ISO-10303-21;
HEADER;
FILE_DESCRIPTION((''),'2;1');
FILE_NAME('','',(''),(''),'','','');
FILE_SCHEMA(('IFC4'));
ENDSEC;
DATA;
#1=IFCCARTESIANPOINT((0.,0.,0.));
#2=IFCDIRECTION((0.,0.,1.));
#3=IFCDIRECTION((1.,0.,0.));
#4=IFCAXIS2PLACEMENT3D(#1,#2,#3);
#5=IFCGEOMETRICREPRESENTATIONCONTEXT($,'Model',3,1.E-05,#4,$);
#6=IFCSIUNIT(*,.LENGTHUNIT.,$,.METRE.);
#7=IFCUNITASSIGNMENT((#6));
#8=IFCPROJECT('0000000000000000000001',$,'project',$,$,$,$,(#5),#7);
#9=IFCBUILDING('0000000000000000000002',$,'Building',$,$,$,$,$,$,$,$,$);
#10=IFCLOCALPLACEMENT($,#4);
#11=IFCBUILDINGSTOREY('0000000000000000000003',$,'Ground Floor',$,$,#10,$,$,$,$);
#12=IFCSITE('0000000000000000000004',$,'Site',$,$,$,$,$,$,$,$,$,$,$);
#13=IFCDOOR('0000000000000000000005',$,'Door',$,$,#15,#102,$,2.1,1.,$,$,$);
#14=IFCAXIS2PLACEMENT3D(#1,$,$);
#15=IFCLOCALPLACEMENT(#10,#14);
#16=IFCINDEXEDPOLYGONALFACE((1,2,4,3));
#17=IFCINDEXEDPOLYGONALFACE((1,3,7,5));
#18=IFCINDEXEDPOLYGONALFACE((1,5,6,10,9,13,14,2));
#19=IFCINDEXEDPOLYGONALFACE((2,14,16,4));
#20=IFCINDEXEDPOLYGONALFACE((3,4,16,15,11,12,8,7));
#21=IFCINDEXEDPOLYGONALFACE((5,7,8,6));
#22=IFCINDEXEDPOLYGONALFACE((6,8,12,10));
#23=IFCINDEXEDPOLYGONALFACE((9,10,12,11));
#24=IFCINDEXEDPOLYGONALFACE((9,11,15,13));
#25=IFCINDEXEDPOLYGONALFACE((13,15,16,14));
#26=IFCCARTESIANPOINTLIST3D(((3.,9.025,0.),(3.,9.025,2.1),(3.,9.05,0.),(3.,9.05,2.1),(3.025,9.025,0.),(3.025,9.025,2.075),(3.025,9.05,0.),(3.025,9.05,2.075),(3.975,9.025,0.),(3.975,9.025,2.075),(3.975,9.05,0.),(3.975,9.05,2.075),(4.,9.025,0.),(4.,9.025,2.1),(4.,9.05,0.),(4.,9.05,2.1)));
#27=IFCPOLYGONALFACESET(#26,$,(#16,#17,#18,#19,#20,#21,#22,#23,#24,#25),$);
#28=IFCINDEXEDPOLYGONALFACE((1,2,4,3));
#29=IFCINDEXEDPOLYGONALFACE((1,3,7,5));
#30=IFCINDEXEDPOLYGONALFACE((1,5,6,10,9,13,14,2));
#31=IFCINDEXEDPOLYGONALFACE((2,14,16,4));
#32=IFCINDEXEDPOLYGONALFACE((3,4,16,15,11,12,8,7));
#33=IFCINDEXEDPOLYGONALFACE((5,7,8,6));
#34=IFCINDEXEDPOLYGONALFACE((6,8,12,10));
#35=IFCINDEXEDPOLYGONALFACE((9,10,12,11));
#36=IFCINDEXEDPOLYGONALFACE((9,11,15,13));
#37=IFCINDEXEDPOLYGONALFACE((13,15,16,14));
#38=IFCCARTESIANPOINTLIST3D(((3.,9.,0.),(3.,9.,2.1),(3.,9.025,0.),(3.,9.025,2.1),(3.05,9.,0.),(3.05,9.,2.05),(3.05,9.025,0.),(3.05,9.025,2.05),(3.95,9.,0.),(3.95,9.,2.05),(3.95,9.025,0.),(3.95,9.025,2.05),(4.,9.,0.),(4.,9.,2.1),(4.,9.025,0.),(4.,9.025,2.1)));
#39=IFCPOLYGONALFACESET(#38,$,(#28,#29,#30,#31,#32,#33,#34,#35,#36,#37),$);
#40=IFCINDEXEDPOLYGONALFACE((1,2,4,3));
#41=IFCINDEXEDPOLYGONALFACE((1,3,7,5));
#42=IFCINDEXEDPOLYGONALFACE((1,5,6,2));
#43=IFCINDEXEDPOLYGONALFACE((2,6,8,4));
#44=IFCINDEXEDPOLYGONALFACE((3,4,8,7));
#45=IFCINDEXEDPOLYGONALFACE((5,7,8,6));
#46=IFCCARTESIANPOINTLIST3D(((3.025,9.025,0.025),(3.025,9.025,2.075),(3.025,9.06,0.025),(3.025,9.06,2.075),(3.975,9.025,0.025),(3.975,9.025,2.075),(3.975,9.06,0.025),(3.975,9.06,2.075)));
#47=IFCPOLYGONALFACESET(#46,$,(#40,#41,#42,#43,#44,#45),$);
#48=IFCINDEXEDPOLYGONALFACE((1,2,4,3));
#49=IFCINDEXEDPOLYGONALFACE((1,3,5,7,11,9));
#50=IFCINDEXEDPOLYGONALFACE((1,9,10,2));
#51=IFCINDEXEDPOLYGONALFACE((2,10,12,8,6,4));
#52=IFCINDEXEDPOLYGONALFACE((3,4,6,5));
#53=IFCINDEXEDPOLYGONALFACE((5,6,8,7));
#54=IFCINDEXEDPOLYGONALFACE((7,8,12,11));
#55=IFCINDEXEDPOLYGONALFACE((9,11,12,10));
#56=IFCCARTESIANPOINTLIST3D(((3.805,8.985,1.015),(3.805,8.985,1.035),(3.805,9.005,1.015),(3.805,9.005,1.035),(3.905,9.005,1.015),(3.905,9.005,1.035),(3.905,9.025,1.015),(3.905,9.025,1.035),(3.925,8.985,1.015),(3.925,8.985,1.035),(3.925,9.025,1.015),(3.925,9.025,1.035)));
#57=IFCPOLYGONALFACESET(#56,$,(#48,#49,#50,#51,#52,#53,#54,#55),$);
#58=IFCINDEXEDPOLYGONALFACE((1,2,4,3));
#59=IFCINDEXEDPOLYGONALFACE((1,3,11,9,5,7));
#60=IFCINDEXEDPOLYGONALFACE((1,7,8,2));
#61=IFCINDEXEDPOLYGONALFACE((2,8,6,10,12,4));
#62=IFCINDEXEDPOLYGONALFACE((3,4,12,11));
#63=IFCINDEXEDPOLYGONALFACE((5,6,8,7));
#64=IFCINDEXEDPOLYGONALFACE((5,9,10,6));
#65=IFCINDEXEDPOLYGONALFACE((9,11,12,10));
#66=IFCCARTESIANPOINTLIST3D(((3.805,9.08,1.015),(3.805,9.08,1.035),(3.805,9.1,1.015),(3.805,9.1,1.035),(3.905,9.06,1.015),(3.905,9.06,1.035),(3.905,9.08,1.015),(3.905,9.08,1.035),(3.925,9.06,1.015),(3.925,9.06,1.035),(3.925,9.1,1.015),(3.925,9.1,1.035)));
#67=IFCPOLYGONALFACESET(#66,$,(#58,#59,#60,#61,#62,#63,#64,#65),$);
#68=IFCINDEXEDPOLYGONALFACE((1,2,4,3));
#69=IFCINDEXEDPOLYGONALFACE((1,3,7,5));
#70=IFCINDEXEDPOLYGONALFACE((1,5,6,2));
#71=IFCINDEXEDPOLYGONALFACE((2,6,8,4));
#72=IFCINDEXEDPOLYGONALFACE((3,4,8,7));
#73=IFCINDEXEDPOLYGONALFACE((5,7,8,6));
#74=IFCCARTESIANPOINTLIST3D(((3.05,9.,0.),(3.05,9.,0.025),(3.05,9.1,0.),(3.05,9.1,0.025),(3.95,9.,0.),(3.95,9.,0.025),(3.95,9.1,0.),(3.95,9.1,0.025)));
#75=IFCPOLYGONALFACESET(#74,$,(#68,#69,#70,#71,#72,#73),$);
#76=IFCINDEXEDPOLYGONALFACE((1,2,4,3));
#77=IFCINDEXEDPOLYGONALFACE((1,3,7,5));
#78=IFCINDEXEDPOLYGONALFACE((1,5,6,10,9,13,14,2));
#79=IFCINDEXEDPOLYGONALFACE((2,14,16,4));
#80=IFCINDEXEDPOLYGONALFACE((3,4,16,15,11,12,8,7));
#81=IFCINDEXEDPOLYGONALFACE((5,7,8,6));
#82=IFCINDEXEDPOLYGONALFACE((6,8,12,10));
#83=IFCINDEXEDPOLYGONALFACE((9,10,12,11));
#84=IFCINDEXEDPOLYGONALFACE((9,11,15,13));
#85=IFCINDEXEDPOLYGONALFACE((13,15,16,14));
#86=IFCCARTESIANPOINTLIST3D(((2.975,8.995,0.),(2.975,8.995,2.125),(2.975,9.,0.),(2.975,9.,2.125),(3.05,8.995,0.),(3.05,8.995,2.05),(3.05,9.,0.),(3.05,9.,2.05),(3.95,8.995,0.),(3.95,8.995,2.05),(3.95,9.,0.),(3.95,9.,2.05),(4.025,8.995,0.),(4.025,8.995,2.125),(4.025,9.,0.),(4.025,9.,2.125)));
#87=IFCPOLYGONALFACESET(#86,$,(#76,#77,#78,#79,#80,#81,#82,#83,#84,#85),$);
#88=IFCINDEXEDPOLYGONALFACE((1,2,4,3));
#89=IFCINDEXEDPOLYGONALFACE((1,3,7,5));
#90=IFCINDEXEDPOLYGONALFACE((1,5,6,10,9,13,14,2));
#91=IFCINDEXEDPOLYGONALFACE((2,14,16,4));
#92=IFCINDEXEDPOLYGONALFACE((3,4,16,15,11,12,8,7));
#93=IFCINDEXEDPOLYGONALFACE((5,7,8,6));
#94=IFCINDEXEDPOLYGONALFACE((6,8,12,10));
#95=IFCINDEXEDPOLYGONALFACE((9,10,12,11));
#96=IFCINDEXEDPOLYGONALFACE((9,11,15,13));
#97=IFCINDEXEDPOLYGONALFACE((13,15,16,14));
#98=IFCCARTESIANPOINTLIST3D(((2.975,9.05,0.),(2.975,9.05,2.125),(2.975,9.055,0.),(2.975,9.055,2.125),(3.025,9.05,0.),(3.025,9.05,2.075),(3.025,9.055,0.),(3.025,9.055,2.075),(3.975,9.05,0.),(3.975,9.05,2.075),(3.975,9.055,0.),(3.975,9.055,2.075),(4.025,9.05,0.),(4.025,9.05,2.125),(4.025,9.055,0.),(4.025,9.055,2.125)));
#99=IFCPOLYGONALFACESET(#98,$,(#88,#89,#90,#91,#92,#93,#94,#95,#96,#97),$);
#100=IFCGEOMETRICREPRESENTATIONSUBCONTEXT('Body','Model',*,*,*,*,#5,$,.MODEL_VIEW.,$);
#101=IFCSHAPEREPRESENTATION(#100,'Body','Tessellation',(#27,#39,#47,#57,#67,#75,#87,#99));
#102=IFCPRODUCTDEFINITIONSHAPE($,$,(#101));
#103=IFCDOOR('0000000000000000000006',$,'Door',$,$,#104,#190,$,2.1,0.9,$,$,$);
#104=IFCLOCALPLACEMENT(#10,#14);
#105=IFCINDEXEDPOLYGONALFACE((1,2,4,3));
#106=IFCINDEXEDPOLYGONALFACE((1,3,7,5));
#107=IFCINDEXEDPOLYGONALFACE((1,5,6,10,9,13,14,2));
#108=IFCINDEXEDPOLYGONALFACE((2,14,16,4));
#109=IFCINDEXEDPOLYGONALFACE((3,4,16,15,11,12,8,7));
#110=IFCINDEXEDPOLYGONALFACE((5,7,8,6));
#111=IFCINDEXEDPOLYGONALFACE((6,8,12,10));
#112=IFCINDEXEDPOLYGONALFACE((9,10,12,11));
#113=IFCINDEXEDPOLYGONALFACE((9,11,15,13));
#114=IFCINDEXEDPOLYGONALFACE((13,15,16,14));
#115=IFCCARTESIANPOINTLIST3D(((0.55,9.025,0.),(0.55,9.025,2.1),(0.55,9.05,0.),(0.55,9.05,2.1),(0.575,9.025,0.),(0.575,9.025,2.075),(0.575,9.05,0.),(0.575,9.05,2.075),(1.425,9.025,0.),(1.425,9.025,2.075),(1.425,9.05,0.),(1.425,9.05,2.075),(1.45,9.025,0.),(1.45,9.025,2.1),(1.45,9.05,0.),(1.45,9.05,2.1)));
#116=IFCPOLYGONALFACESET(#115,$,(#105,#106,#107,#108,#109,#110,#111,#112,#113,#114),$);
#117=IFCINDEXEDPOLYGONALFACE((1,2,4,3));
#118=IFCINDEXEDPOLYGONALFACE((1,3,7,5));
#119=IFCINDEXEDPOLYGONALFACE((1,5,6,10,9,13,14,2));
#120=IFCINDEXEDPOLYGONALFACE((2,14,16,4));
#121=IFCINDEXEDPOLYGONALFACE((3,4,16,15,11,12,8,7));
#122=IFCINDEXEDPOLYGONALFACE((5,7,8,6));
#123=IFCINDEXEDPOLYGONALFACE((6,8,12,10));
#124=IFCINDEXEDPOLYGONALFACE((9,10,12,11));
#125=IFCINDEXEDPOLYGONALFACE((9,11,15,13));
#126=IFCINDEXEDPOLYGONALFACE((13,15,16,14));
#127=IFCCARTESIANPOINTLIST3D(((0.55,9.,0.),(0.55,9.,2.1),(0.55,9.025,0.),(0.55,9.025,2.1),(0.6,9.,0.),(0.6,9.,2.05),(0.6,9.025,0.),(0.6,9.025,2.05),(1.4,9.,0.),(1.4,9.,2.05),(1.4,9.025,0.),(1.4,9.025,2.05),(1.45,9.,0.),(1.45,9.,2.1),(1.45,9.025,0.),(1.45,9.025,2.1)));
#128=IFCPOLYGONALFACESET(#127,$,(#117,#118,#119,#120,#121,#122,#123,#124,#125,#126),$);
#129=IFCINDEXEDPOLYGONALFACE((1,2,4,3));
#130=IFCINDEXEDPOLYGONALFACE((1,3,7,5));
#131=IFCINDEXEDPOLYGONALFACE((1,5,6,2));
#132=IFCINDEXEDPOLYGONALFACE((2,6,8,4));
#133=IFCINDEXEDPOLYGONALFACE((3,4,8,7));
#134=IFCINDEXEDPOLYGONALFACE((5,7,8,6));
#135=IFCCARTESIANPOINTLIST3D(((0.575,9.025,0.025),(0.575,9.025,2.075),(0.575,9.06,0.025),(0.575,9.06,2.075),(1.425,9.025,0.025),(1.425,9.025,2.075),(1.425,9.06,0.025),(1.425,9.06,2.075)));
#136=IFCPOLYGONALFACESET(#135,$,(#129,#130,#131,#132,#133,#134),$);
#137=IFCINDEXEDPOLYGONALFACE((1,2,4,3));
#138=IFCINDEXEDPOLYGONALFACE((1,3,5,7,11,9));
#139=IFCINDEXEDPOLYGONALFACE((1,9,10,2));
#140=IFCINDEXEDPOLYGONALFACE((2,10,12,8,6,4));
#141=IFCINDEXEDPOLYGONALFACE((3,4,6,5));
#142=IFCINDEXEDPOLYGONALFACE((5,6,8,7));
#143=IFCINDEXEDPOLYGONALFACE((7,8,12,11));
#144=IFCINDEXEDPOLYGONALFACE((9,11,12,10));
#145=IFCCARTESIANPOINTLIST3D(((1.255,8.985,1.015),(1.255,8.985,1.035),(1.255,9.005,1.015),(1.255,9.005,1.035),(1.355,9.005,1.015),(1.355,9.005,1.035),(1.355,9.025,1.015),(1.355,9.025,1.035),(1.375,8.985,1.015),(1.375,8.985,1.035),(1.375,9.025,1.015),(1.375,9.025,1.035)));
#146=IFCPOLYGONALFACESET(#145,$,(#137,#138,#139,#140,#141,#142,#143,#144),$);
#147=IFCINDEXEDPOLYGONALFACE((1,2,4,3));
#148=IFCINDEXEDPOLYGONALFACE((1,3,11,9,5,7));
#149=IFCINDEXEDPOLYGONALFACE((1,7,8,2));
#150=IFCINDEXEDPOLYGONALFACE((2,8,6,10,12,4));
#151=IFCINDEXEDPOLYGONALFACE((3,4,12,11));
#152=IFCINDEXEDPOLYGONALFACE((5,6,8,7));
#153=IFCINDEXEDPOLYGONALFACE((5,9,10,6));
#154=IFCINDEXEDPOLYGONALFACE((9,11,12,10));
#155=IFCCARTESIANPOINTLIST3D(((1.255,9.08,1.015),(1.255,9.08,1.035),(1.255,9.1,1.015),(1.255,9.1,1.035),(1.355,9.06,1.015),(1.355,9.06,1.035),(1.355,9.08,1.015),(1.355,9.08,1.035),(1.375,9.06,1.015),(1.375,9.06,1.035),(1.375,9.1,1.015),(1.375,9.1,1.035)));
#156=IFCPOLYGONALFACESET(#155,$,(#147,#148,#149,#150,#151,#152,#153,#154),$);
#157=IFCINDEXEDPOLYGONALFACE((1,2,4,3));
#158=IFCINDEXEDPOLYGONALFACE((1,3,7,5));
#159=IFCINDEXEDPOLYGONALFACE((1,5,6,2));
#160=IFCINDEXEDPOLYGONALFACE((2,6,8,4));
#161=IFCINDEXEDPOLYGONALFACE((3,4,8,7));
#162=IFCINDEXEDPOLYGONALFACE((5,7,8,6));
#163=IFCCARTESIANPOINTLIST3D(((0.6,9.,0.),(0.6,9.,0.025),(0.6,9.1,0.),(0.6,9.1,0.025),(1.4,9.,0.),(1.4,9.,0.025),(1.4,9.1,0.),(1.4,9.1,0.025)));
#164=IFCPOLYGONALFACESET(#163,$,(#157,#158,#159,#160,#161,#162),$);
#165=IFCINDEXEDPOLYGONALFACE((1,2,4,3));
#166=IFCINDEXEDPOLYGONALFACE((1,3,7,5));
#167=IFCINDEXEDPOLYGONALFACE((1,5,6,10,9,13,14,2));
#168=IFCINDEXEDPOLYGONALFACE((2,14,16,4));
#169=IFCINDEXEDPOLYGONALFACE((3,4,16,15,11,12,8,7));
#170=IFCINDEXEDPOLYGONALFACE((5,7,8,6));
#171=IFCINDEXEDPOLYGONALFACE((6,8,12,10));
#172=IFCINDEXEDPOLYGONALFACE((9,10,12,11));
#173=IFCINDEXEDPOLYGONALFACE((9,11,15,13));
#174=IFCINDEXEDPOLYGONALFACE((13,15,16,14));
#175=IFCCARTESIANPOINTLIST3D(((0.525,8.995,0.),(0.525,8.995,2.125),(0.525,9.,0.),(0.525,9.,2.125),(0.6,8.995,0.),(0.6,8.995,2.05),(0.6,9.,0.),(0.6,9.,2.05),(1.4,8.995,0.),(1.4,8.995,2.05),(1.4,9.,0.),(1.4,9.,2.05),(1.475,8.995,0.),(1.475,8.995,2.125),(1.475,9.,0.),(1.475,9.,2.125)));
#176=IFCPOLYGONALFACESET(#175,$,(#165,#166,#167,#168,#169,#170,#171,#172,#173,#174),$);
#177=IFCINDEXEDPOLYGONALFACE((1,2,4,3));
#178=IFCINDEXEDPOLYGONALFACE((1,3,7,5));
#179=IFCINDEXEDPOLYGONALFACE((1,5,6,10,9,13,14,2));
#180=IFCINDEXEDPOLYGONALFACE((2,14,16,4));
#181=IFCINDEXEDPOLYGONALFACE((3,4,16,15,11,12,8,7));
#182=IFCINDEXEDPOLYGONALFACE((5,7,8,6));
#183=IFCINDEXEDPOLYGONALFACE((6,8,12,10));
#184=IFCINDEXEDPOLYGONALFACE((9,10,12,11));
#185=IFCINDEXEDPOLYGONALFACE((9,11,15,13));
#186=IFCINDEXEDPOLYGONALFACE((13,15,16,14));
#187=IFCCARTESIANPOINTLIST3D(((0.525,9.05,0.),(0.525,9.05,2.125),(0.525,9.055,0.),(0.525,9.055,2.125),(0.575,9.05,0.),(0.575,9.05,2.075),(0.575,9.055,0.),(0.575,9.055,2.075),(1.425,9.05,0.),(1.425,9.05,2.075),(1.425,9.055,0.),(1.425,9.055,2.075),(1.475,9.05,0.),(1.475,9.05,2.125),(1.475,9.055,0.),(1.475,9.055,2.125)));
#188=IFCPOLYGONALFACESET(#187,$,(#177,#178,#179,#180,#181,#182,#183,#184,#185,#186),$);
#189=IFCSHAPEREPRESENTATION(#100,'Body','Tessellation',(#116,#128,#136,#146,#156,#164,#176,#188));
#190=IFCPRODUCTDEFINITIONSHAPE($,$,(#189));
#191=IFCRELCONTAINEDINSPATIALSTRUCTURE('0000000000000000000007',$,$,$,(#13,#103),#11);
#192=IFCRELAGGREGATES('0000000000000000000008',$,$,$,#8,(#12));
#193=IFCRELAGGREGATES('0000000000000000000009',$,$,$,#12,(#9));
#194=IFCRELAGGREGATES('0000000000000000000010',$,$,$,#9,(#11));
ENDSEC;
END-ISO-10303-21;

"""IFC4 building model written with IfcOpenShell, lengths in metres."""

from ifc_helpers import new_model, si_unit, frame, origin_with_axes, place, context, subcontext, project, spatial, line, indexed_curve, outline, extrude, element, save


model = new_model("IFC4")

# Units and contexts
model_context = context("Model", 3, precision=1e-05, world=origin_with_axes())
body_context = subcontext(model_context, "Body", "Model", "MODEL_VIEW")
ifc_project = project(units=[si_unit("LENGTHUNIT", "METRE")], contexts=[model_context])

# Site, building, storey
site = spatial("IfcSite", under=ifc_project, Name="Site")
building = spatial("IfcBuilding", under=site, Name="Building")
storey_placement = place(None, origin_with_axes())
storey = spatial("IfcBuildingStorey", under=building, at=storey_placement, Name="Ground Floor")

# Doors
door_1_placement = place(storey_placement, frame((3.0, 9.0, 0.0), z_axis=(0.0, 0.0, 1.0), x_axis=(1.0, 0.0, 0.0)))
element("IfcDoor", 1, at=door_1_placement, inside=storey, Name="Door", OverallHeight=2.1, OverallWidth=1.0, context=body_context, shape_type="SweptSolid", body=[
    extrude(outline(indexed_curve([(0.0, 0.0), (0.0, 2.1), (1.0, 2.1), (1.0, 0.0), (0.975, 0.0), (0.975, 2.075), (0.025, 2.075), (0.025, 0.0)], segments=[line(1, 2, 3, 4, 5, 6, 7, 8, 1)])), frame((0.0, 0.025, 0.0), z_axis=(0.0, -1.0, 0.0), x_axis=(1.0, 0.0, 0.0)), (0.0, 0.0, -1.0), 0.025),
    extrude(outline(indexed_curve([(0.0, 0.0), (0.0, 2.1), (1.0, 2.1), (1.0, 0.0), (0.95, 0.0), (0.95, 2.05), (0.05, 2.05), (0.05, 0.0)], segments=[line(1, 2, 3, 4, 5, 6, 7, 8, 1)])), frame((0.0, 0.0, 0.0), z_axis=(0.0, -1.0, 0.0), x_axis=(1.0, 0.0, 0.0)), (0.0, 0.0, -1.0), 0.025),
    extrude(outline(indexed_curve([(0.0, 0.0), (0.95, 0.0), (0.95, 0.035), (0.0, 0.035)], segments=[line(1, 2, 3, 4, 1)])), frame((0.025, 0.025, 0.025), z_axis=(0.0, 0.0, 1.0), x_axis=(1.0, 0.0, 0.0)), (0.0, 0.0, 1.0), 2.05),
    extrude(outline(indexed_curve([(0.0, 0.0), (0.0, -0.04), (-0.12, -0.04), (-0.12, -0.02), (-0.02, -0.02), (-0.02, 0.0)], segments=[line(1, 2, 3, 4, 5, 6, 1)])), frame((0.925, 0.025, 1.015), z_axis=(0.0, 0.0, 1.0), x_axis=(1.0, 0.0, 0.0)), (0.0, 0.0, 1.0), 0.02),
    extrude(outline(indexed_curve([(0.0, 0.0), (0.0, 0.04), (-0.12, 0.04), (-0.12, 0.02), (-0.02, 0.02), (-0.02, 0.0)], segments=[line(1, 2, 3, 4, 5, 6, 1)])), frame((0.925, 0.06, 1.015), z_axis=(0.0, 0.0, 1.0), x_axis=(1.0, 0.0, 0.0)), (0.0, 0.0, 1.0), 0.02),
    extrude(outline(indexed_curve([(0.0, 0.0), (0.9, 0.0), (0.9, 0.1), (0.0, 0.1)], segments=[line(1, 2, 3, 4, 1)])), frame((0.05, 0.0, 0.0), z_axis=(0.0, 0.0, 1.0), x_axis=(1.0, 0.0, 0.0)), (0.0, 0.0, 1.0), 0.025),
    extrude(outline(indexed_curve([(0.0, 0.0), (0.0, 2.125), (1.05, 2.125), (1.05, 0.0), (0.975, 0.0), (0.975, 2.05), (0.075, 2.05), (0.075, 0.0)], segments=[line(1, 2, 3, 4, 5, 6, 7, 8, 1)])), frame((-0.025, -0.005, 0.0), z_axis=(0.0, -1.0, 0.0), x_axis=(1.0, 0.0, 0.0)), (0.0, 0.0, -1.0), 0.005),
    extrude(outline(indexed_curve([(0.0, 0.0), (0.0, 2.125), (1.05, 2.125), (1.05, 0.0), (1.0, 0.0), (1.0, 2.075), (0.05, 2.075), (0.05, 0.0)], segments=[line(1, 2, 3, 4, 5, 6, 7, 8, 1)])), frame((-0.025, 0.05, 0.0), z_axis=(0.0, -1.0, 0.0), x_axis=(1.0, 0.0, 0.0)), (0.0, 0.0, -1.0), 0.005),
])
door_2_placement = place(storey_placement, frame((0.55, 9.0, 0.0), z_axis=(0.0, 0.0, 1.0), x_axis=(1.0, 0.0, 0.0)))
element("IfcDoor", 2, at=door_2_placement, inside=storey, Name="Door", OverallHeight=2.1, OverallWidth=0.9, context=body_context, shape_type="SweptSolid", body=[
    extrude(outline(indexed_curve([(0.0, 0.0), (0.0, 2.1), (0.9, 2.1), (0.9, 0.0), (0.875, 0.0), (0.875, 2.075), (0.025, 2.075), (0.025, 0.0)], segments=[line(1, 2, 3, 4, 5, 6, 7, 8, 1)])), frame((0.0, 0.025, 0.0), z_axis=(0.0, -1.0, 0.0), x_axis=(1.0, 0.0, 0.0)), (0.0, 0.0, -1.0), 0.025),
    extrude(outline(indexed_curve([(0.0, 0.0), (0.0, 2.1), (0.9, 2.1), (0.9, 0.0), (0.85, 0.0), (0.85, 2.05), (0.05, 2.05), (0.05, 0.0)], segments=[line(1, 2, 3, 4, 5, 6, 7, 8, 1)])), frame((0.0, 0.0, 0.0), z_axis=(0.0, -1.0, 0.0), x_axis=(1.0, 0.0, 0.0)), (0.0, 0.0, -1.0), 0.025),
    extrude(outline(indexed_curve([(0.0, 0.0), (0.85, 0.0), (0.85, 0.035), (0.0, 0.035)], segments=[line(1, 2, 3, 4, 1)])), frame((0.025, 0.025, 0.025), z_axis=(0.0, 0.0, 1.0), x_axis=(1.0, 0.0, 0.0)), (0.0, 0.0, 1.0), 2.05),
    extrude(outline(indexed_curve([(0.0, 0.0), (0.0, -0.04), (-0.12, -0.04), (-0.12, -0.02), (-0.02, -0.02), (-0.02, 0.0)], segments=[line(1, 2, 3, 4, 5, 6, 1)])), frame((0.825, 0.025, 1.015), z_axis=(0.0, 0.0, 1.0), x_axis=(1.0, 0.0, 0.0)), (0.0, 0.0, 1.0), 0.02),
    extrude(outline(indexed_curve([(0.0, 0.0), (0.0, 0.04), (-0.12, 0.04), (-0.12, 0.02), (-0.02, 0.02), (-0.02, 0.0)], segments=[line(1, 2, 3, 4, 5, 6, 1)])), frame((0.825, 0.06, 1.015), z_axis=(0.0, 0.0, 1.0), x_axis=(1.0, 0.0, 0.0)), (0.0, 0.0, 1.0), 0.02),
    extrude(outline(indexed_curve([(0.0, 0.0), (0.8, 0.0), (0.8, 0.1), (0.0, 0.1)], segments=[line(1, 2, 3, 4, 1)])), frame((0.05, 0.0, 0.0), z_axis=(0.0, 0.0, 1.0), x_axis=(1.0, 0.0, 0.0)), (0.0, 0.0, 1.0), 0.025),
    extrude(outline(indexed_curve([(0.0, 0.0), (0.0, 2.125), (0.95, 2.125), (0.95, 0.0), (0.875, 0.0), (0.875, 2.05), (0.075, 2.05), (0.075, 0.0)], segments=[line(1, 2, 3, 4, 5, 6, 7, 8, 1)])), frame((-0.025, -0.005, 0.0), z_axis=(0.0, -1.0, 0.0), x_axis=(1.0, 0.0, 0.0)), (0.0, 0.0, -1.0), 0.005),
    extrude(outline(indexed_curve([(0.0, 0.0), (0.0, 2.125), (0.95, 2.125), (0.95, 0.0), (0.9, 0.0), (0.9, 2.075), (0.05, 2.075), (0.05, 0.0)], segments=[line(1, 2, 3, 4, 5, 6, 7, 8, 1)])), frame((-0.025, 0.05, 0.0), z_axis=(0.0, -1.0, 0.0), x_axis=(1.0, 0.0, 0.0)), (0.0, 0.0, -1.0), 0.005),
])

save(model, "model.ifc")
